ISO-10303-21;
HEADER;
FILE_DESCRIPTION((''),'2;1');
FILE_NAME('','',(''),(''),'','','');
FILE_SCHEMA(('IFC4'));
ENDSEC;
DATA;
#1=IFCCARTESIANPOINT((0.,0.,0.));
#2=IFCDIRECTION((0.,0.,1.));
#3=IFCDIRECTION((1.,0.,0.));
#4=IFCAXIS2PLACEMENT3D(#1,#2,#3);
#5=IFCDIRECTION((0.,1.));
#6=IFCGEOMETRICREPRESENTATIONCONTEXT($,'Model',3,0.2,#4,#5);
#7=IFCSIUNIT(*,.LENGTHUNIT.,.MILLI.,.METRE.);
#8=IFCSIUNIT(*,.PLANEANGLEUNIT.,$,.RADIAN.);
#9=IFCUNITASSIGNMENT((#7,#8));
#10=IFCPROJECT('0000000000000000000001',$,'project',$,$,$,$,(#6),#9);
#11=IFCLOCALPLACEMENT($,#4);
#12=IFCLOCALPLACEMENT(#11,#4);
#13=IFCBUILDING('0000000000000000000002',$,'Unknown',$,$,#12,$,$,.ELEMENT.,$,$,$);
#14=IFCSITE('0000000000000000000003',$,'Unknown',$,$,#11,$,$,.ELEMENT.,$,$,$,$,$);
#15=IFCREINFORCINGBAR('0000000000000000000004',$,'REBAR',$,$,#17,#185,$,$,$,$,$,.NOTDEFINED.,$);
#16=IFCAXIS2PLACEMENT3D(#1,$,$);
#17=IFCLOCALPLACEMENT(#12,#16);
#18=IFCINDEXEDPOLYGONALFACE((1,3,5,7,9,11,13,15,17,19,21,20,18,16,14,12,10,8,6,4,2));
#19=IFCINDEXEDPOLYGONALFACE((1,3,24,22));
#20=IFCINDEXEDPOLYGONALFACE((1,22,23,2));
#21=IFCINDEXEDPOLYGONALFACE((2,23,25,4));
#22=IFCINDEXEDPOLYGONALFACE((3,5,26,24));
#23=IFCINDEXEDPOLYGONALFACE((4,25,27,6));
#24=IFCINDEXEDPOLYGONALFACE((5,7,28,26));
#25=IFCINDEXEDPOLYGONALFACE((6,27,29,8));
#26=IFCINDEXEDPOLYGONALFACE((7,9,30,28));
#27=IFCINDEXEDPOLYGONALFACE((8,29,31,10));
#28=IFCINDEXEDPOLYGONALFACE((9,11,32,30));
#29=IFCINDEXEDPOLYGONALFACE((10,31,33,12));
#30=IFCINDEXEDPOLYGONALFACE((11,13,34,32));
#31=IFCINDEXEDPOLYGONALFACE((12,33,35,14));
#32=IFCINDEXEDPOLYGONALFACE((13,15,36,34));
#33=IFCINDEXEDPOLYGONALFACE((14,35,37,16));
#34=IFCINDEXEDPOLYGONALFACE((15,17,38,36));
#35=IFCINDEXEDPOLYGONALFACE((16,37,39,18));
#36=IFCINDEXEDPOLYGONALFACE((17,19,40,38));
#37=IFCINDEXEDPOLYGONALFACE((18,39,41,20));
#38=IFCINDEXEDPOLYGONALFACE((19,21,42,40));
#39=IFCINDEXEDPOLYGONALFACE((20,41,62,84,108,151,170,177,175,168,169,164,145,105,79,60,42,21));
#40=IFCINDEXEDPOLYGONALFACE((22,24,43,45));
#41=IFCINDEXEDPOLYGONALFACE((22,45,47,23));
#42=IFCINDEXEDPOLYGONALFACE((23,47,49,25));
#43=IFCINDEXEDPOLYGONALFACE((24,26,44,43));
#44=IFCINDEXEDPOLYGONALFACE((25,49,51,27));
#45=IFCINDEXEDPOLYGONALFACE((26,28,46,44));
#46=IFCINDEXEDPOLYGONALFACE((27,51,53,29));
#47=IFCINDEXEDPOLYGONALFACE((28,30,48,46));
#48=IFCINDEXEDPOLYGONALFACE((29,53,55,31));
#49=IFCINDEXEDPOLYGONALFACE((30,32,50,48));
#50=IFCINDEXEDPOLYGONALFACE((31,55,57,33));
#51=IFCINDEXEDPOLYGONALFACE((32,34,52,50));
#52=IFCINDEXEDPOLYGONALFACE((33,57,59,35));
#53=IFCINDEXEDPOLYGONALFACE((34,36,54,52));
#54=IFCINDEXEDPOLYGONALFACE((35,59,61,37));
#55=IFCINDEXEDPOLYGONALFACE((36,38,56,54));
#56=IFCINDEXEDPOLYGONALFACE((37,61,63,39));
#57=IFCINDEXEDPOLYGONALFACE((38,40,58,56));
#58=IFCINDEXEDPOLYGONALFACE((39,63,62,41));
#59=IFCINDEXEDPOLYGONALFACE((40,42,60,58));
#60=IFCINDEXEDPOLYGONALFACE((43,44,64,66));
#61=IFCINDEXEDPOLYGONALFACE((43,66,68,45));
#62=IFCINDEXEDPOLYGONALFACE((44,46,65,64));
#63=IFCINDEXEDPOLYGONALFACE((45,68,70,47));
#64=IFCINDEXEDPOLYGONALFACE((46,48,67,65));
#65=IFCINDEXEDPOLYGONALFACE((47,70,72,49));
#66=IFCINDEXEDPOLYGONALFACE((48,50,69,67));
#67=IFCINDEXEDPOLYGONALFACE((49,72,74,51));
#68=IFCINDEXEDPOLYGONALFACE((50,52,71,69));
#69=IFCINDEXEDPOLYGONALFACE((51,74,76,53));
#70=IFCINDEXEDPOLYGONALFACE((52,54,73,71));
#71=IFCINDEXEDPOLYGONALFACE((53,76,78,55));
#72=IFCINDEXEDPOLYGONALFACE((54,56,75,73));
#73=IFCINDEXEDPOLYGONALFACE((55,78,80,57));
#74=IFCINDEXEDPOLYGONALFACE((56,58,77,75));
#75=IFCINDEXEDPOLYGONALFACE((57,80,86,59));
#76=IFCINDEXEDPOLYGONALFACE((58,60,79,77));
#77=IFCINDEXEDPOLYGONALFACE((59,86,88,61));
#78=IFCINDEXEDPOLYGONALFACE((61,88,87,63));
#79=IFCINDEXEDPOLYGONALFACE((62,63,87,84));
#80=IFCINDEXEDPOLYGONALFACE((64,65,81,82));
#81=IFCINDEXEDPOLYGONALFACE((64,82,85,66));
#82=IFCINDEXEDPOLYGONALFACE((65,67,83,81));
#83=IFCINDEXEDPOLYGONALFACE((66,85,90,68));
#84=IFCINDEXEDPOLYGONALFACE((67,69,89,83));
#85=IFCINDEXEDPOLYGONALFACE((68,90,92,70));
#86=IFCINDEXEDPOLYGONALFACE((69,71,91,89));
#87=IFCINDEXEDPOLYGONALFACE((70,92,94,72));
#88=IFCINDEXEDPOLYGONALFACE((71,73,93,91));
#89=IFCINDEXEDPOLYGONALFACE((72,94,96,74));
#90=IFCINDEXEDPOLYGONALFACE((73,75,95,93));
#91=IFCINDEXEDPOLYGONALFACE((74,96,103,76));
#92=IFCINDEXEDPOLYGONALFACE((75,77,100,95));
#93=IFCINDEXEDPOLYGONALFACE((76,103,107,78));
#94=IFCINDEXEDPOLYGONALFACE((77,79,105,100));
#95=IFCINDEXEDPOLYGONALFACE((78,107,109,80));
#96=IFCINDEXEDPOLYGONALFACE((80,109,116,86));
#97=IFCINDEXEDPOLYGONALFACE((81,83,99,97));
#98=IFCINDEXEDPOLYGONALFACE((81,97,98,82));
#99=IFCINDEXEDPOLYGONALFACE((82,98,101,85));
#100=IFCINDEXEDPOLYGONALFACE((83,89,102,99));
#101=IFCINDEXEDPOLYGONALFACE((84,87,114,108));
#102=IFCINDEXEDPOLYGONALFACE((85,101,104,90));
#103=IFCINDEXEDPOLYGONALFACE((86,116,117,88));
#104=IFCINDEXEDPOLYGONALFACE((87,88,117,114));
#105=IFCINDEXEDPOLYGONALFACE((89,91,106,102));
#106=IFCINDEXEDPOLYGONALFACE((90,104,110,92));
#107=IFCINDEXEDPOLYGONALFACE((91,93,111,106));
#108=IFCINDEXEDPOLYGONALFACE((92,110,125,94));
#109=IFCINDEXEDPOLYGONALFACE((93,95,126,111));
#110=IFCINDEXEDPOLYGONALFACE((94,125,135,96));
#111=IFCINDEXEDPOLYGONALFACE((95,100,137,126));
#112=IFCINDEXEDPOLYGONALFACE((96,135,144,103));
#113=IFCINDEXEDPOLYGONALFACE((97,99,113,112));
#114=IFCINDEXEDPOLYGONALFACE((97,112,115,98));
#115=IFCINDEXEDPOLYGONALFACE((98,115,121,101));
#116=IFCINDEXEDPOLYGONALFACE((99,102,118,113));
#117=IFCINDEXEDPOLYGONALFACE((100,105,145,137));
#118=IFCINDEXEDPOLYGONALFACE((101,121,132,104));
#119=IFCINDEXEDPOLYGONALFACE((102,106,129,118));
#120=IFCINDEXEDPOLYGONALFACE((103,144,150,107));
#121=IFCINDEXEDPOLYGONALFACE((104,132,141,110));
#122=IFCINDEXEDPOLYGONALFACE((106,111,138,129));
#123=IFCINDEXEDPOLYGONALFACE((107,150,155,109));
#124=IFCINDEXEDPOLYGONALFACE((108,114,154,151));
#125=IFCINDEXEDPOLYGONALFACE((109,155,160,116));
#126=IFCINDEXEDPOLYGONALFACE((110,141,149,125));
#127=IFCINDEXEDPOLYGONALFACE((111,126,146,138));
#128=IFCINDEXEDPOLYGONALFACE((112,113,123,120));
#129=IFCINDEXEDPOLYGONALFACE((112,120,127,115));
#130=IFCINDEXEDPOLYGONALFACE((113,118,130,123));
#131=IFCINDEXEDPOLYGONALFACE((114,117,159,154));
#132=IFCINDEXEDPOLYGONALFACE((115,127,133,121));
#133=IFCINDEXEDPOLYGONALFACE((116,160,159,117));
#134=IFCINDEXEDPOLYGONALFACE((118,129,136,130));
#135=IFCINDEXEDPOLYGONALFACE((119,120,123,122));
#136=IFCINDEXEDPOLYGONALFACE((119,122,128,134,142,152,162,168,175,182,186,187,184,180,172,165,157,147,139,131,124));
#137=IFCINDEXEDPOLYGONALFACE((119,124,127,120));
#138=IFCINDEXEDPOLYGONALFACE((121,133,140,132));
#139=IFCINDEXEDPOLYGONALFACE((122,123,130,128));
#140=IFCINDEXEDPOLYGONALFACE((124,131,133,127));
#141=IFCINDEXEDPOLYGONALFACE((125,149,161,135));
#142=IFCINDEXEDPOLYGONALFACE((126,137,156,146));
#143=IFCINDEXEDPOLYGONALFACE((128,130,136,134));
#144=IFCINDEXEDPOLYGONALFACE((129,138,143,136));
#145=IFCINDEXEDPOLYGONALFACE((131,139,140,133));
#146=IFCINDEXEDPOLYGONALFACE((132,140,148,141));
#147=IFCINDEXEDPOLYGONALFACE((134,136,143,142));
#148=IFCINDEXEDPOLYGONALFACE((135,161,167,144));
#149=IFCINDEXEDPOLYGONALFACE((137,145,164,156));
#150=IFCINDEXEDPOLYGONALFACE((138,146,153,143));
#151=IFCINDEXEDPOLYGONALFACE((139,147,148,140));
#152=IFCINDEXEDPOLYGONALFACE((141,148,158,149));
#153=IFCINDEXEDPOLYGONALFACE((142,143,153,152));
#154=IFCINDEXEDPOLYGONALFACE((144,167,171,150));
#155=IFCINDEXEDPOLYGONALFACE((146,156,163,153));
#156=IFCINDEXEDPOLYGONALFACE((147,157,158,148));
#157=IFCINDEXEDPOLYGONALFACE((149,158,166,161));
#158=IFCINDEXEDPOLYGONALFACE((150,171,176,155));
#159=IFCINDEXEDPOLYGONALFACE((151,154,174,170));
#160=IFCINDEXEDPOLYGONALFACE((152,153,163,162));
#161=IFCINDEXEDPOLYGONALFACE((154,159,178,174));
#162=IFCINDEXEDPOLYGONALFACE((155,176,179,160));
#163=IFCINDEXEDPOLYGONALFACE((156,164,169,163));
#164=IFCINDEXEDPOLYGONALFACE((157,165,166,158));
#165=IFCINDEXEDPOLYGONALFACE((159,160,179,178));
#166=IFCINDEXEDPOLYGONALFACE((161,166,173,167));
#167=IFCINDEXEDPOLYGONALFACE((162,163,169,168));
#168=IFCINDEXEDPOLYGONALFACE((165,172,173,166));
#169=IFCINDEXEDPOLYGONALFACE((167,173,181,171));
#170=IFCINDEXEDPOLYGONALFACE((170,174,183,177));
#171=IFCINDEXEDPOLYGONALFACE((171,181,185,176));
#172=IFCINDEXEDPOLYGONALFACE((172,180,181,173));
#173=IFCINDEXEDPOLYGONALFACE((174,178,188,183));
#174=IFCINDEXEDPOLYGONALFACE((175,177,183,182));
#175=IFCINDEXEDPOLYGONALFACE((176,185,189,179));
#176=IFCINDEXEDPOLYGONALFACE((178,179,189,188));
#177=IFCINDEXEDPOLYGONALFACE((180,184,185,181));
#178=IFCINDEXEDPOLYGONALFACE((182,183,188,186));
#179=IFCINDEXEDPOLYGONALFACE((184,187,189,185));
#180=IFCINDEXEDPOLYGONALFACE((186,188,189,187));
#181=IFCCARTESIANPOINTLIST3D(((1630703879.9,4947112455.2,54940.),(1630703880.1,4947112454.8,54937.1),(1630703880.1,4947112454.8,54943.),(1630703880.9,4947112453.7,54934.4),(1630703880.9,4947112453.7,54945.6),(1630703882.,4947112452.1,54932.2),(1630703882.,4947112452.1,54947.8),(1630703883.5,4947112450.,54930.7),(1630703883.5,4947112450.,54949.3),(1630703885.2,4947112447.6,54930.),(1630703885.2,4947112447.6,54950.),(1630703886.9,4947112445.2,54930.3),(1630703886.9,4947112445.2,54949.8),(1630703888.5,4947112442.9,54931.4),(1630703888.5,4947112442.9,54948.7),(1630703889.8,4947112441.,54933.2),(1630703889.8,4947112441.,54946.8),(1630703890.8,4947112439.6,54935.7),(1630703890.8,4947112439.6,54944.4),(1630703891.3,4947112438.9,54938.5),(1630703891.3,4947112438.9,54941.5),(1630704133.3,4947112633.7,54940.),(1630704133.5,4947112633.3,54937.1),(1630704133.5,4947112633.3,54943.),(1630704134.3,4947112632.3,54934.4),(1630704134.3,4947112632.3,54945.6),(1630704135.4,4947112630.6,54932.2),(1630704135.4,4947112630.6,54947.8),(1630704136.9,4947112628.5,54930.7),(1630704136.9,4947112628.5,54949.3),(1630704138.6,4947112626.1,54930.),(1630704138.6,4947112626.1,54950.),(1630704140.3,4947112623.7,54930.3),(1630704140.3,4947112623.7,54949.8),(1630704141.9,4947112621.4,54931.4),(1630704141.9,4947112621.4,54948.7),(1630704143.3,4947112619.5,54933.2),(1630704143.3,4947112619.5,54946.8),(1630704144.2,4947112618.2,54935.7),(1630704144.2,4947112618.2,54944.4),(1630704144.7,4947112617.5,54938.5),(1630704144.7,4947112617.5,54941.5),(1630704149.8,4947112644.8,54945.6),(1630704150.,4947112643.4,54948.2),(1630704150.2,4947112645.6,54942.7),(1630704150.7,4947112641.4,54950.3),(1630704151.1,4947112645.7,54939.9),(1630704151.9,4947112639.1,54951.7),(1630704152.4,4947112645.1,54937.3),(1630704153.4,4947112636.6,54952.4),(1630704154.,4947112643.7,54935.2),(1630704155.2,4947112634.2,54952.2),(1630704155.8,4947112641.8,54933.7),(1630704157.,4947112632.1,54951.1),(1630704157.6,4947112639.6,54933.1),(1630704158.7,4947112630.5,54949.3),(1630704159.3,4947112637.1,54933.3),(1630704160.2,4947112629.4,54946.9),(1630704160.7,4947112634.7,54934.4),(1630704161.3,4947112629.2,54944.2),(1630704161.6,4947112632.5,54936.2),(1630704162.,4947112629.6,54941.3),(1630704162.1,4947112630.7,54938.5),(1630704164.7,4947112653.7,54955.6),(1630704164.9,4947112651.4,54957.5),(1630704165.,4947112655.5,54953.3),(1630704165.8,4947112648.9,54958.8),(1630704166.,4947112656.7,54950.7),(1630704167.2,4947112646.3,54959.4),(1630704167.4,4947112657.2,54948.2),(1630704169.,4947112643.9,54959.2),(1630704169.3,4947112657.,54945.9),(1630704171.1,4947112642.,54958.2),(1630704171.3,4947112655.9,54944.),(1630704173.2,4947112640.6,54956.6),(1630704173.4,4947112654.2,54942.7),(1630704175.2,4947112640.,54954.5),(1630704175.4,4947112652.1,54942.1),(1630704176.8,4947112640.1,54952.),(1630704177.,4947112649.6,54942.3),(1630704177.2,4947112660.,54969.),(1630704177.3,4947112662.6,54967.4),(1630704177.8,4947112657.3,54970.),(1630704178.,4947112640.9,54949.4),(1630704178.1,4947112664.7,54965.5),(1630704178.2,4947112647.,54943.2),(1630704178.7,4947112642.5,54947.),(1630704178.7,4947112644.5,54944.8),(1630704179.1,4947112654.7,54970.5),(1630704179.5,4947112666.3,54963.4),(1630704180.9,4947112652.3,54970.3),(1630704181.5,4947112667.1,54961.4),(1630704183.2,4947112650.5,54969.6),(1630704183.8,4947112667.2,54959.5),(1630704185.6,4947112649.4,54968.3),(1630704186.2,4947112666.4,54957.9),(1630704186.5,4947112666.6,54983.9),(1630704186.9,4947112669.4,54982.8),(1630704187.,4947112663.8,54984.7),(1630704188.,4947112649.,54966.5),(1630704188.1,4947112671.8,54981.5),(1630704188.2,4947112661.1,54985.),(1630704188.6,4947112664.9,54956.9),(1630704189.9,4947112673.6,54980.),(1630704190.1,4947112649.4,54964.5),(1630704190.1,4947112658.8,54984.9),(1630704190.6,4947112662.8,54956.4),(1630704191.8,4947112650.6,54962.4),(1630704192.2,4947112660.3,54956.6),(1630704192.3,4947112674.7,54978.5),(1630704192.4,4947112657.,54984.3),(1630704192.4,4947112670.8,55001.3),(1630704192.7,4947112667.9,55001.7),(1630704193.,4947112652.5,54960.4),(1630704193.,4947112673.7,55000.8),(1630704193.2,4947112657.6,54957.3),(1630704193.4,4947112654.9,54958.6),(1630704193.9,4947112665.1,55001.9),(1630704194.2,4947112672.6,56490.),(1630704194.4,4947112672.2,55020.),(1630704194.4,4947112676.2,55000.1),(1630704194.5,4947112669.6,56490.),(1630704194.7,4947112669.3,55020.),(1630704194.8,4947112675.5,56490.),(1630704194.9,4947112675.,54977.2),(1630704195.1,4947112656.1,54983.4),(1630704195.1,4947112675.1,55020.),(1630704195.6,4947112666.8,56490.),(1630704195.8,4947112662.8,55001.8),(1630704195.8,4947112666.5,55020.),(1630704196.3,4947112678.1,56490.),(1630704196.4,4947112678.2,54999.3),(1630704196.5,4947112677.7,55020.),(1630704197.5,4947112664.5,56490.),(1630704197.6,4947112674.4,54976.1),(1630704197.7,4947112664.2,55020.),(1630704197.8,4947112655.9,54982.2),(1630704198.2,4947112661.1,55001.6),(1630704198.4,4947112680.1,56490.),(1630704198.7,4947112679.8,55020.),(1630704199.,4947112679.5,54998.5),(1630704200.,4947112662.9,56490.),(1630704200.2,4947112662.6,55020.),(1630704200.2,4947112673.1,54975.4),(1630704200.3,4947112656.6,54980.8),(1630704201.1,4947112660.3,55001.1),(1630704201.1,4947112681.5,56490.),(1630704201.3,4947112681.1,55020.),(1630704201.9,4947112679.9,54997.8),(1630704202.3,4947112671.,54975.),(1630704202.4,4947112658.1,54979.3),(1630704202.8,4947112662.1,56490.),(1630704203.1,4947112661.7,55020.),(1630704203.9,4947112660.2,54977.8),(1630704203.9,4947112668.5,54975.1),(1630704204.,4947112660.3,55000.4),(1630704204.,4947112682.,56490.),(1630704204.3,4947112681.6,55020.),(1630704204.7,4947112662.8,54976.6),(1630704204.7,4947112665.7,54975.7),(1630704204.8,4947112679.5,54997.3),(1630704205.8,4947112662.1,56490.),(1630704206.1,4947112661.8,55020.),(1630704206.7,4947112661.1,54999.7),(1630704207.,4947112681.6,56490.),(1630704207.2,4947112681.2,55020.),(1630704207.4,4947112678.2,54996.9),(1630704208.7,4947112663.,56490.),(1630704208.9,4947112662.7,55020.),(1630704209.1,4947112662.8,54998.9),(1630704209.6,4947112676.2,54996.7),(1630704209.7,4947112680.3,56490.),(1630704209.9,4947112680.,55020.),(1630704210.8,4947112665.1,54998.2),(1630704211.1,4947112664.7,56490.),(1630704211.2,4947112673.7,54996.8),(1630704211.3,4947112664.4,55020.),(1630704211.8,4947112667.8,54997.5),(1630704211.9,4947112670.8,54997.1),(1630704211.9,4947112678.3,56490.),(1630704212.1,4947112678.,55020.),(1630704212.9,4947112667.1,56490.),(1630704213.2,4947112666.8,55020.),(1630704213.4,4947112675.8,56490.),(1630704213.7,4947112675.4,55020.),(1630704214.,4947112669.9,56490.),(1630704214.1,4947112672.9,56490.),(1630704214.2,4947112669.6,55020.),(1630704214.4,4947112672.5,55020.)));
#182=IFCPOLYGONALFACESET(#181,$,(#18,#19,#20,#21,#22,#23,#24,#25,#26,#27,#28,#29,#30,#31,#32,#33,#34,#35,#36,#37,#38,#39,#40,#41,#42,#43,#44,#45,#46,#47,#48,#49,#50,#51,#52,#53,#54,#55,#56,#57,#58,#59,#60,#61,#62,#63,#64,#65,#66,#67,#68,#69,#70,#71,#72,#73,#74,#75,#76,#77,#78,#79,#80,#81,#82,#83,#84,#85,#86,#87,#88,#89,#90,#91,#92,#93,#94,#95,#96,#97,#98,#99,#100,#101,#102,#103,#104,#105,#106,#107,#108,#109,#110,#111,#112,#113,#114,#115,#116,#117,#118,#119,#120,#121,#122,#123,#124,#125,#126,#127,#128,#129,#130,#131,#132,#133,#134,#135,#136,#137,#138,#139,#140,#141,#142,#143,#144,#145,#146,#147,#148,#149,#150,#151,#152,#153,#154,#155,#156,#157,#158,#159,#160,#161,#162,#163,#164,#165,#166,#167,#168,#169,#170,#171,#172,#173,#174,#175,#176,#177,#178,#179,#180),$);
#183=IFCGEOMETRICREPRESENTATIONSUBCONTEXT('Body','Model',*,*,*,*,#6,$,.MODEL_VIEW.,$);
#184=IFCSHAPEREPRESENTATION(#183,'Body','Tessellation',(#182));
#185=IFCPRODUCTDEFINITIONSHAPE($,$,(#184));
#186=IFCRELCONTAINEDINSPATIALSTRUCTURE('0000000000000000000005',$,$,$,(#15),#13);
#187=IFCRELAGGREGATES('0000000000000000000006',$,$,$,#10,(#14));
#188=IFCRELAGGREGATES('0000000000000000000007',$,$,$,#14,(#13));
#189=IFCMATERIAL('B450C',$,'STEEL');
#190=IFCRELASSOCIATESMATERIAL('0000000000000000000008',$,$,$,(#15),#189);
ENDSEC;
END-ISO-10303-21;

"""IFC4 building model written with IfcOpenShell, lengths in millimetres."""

from ifc_helpers import new_model, entity, si_unit, direction, frame, origin_with_axes, place, context, subcontext, project, spatial, material, element, save


model = new_model("IFC4")

# Units and contexts
model_context = context("Model", 3, precision=0.2, world=origin_with_axes(), true_north=direction((0.0, 1.0)))
body_context = subcontext(model_context, "Body", "Model", "MODEL_VIEW")
ifc_project = project(units=[si_unit("LENGTHUNIT", "METRE", prefix="MILLI"), si_unit("PLANEANGLEUNIT", "RADIAN")], contexts=[model_context])

# Site, building
site_placement = place(None, origin_with_axes())
site = spatial("IfcSite", under=ifc_project, at=site_placement, Name="Unknown", CompositionType="ELEMENT")
building_placement = place(site_placement, origin_with_axes())
building = spatial("IfcBuilding", under=site, at=building_placement, Name="Unknown", CompositionType="ELEMENT")

# Reinforcing bar
ifc_material = material(Name="B450C", Category="STEEL")
reinforcing_bar_1_placement = place(building_placement, frame((1630704216.5, 4947112741.3, 54890.0), z_axis=(0.575962, -0.817477, 0.0), x_axis=(0.0, 0.0, 1.0)))
element("IfcReinforcingBar", 1, at=reinforcing_bar_1_placement, inside=building, material=ifc_material, Name="REBAR", PredefinedType="NOTDEFINED", context=body_context, shape_type="AdvancedSweptSolid", body=[
    entity("IfcSweptDiskSolid", entity("IfcIndexedPolyCurve", entity("IfcCartesianPointList3D", [[50.0, 440.0, 50.0], [50.0, 130.0, 50.0], [73.4, 73.4, 50.0], [130.0, 50.0, 50.0], [1600.0, 50.0, 49.5]]), [entity("IfcLineIndex", [1, 2]), entity("IfcArcIndex", [2, 3, 4]), entity("IfcLineIndex", [4, 5])]), 10.0),
])

save(model, "model.ifc")
